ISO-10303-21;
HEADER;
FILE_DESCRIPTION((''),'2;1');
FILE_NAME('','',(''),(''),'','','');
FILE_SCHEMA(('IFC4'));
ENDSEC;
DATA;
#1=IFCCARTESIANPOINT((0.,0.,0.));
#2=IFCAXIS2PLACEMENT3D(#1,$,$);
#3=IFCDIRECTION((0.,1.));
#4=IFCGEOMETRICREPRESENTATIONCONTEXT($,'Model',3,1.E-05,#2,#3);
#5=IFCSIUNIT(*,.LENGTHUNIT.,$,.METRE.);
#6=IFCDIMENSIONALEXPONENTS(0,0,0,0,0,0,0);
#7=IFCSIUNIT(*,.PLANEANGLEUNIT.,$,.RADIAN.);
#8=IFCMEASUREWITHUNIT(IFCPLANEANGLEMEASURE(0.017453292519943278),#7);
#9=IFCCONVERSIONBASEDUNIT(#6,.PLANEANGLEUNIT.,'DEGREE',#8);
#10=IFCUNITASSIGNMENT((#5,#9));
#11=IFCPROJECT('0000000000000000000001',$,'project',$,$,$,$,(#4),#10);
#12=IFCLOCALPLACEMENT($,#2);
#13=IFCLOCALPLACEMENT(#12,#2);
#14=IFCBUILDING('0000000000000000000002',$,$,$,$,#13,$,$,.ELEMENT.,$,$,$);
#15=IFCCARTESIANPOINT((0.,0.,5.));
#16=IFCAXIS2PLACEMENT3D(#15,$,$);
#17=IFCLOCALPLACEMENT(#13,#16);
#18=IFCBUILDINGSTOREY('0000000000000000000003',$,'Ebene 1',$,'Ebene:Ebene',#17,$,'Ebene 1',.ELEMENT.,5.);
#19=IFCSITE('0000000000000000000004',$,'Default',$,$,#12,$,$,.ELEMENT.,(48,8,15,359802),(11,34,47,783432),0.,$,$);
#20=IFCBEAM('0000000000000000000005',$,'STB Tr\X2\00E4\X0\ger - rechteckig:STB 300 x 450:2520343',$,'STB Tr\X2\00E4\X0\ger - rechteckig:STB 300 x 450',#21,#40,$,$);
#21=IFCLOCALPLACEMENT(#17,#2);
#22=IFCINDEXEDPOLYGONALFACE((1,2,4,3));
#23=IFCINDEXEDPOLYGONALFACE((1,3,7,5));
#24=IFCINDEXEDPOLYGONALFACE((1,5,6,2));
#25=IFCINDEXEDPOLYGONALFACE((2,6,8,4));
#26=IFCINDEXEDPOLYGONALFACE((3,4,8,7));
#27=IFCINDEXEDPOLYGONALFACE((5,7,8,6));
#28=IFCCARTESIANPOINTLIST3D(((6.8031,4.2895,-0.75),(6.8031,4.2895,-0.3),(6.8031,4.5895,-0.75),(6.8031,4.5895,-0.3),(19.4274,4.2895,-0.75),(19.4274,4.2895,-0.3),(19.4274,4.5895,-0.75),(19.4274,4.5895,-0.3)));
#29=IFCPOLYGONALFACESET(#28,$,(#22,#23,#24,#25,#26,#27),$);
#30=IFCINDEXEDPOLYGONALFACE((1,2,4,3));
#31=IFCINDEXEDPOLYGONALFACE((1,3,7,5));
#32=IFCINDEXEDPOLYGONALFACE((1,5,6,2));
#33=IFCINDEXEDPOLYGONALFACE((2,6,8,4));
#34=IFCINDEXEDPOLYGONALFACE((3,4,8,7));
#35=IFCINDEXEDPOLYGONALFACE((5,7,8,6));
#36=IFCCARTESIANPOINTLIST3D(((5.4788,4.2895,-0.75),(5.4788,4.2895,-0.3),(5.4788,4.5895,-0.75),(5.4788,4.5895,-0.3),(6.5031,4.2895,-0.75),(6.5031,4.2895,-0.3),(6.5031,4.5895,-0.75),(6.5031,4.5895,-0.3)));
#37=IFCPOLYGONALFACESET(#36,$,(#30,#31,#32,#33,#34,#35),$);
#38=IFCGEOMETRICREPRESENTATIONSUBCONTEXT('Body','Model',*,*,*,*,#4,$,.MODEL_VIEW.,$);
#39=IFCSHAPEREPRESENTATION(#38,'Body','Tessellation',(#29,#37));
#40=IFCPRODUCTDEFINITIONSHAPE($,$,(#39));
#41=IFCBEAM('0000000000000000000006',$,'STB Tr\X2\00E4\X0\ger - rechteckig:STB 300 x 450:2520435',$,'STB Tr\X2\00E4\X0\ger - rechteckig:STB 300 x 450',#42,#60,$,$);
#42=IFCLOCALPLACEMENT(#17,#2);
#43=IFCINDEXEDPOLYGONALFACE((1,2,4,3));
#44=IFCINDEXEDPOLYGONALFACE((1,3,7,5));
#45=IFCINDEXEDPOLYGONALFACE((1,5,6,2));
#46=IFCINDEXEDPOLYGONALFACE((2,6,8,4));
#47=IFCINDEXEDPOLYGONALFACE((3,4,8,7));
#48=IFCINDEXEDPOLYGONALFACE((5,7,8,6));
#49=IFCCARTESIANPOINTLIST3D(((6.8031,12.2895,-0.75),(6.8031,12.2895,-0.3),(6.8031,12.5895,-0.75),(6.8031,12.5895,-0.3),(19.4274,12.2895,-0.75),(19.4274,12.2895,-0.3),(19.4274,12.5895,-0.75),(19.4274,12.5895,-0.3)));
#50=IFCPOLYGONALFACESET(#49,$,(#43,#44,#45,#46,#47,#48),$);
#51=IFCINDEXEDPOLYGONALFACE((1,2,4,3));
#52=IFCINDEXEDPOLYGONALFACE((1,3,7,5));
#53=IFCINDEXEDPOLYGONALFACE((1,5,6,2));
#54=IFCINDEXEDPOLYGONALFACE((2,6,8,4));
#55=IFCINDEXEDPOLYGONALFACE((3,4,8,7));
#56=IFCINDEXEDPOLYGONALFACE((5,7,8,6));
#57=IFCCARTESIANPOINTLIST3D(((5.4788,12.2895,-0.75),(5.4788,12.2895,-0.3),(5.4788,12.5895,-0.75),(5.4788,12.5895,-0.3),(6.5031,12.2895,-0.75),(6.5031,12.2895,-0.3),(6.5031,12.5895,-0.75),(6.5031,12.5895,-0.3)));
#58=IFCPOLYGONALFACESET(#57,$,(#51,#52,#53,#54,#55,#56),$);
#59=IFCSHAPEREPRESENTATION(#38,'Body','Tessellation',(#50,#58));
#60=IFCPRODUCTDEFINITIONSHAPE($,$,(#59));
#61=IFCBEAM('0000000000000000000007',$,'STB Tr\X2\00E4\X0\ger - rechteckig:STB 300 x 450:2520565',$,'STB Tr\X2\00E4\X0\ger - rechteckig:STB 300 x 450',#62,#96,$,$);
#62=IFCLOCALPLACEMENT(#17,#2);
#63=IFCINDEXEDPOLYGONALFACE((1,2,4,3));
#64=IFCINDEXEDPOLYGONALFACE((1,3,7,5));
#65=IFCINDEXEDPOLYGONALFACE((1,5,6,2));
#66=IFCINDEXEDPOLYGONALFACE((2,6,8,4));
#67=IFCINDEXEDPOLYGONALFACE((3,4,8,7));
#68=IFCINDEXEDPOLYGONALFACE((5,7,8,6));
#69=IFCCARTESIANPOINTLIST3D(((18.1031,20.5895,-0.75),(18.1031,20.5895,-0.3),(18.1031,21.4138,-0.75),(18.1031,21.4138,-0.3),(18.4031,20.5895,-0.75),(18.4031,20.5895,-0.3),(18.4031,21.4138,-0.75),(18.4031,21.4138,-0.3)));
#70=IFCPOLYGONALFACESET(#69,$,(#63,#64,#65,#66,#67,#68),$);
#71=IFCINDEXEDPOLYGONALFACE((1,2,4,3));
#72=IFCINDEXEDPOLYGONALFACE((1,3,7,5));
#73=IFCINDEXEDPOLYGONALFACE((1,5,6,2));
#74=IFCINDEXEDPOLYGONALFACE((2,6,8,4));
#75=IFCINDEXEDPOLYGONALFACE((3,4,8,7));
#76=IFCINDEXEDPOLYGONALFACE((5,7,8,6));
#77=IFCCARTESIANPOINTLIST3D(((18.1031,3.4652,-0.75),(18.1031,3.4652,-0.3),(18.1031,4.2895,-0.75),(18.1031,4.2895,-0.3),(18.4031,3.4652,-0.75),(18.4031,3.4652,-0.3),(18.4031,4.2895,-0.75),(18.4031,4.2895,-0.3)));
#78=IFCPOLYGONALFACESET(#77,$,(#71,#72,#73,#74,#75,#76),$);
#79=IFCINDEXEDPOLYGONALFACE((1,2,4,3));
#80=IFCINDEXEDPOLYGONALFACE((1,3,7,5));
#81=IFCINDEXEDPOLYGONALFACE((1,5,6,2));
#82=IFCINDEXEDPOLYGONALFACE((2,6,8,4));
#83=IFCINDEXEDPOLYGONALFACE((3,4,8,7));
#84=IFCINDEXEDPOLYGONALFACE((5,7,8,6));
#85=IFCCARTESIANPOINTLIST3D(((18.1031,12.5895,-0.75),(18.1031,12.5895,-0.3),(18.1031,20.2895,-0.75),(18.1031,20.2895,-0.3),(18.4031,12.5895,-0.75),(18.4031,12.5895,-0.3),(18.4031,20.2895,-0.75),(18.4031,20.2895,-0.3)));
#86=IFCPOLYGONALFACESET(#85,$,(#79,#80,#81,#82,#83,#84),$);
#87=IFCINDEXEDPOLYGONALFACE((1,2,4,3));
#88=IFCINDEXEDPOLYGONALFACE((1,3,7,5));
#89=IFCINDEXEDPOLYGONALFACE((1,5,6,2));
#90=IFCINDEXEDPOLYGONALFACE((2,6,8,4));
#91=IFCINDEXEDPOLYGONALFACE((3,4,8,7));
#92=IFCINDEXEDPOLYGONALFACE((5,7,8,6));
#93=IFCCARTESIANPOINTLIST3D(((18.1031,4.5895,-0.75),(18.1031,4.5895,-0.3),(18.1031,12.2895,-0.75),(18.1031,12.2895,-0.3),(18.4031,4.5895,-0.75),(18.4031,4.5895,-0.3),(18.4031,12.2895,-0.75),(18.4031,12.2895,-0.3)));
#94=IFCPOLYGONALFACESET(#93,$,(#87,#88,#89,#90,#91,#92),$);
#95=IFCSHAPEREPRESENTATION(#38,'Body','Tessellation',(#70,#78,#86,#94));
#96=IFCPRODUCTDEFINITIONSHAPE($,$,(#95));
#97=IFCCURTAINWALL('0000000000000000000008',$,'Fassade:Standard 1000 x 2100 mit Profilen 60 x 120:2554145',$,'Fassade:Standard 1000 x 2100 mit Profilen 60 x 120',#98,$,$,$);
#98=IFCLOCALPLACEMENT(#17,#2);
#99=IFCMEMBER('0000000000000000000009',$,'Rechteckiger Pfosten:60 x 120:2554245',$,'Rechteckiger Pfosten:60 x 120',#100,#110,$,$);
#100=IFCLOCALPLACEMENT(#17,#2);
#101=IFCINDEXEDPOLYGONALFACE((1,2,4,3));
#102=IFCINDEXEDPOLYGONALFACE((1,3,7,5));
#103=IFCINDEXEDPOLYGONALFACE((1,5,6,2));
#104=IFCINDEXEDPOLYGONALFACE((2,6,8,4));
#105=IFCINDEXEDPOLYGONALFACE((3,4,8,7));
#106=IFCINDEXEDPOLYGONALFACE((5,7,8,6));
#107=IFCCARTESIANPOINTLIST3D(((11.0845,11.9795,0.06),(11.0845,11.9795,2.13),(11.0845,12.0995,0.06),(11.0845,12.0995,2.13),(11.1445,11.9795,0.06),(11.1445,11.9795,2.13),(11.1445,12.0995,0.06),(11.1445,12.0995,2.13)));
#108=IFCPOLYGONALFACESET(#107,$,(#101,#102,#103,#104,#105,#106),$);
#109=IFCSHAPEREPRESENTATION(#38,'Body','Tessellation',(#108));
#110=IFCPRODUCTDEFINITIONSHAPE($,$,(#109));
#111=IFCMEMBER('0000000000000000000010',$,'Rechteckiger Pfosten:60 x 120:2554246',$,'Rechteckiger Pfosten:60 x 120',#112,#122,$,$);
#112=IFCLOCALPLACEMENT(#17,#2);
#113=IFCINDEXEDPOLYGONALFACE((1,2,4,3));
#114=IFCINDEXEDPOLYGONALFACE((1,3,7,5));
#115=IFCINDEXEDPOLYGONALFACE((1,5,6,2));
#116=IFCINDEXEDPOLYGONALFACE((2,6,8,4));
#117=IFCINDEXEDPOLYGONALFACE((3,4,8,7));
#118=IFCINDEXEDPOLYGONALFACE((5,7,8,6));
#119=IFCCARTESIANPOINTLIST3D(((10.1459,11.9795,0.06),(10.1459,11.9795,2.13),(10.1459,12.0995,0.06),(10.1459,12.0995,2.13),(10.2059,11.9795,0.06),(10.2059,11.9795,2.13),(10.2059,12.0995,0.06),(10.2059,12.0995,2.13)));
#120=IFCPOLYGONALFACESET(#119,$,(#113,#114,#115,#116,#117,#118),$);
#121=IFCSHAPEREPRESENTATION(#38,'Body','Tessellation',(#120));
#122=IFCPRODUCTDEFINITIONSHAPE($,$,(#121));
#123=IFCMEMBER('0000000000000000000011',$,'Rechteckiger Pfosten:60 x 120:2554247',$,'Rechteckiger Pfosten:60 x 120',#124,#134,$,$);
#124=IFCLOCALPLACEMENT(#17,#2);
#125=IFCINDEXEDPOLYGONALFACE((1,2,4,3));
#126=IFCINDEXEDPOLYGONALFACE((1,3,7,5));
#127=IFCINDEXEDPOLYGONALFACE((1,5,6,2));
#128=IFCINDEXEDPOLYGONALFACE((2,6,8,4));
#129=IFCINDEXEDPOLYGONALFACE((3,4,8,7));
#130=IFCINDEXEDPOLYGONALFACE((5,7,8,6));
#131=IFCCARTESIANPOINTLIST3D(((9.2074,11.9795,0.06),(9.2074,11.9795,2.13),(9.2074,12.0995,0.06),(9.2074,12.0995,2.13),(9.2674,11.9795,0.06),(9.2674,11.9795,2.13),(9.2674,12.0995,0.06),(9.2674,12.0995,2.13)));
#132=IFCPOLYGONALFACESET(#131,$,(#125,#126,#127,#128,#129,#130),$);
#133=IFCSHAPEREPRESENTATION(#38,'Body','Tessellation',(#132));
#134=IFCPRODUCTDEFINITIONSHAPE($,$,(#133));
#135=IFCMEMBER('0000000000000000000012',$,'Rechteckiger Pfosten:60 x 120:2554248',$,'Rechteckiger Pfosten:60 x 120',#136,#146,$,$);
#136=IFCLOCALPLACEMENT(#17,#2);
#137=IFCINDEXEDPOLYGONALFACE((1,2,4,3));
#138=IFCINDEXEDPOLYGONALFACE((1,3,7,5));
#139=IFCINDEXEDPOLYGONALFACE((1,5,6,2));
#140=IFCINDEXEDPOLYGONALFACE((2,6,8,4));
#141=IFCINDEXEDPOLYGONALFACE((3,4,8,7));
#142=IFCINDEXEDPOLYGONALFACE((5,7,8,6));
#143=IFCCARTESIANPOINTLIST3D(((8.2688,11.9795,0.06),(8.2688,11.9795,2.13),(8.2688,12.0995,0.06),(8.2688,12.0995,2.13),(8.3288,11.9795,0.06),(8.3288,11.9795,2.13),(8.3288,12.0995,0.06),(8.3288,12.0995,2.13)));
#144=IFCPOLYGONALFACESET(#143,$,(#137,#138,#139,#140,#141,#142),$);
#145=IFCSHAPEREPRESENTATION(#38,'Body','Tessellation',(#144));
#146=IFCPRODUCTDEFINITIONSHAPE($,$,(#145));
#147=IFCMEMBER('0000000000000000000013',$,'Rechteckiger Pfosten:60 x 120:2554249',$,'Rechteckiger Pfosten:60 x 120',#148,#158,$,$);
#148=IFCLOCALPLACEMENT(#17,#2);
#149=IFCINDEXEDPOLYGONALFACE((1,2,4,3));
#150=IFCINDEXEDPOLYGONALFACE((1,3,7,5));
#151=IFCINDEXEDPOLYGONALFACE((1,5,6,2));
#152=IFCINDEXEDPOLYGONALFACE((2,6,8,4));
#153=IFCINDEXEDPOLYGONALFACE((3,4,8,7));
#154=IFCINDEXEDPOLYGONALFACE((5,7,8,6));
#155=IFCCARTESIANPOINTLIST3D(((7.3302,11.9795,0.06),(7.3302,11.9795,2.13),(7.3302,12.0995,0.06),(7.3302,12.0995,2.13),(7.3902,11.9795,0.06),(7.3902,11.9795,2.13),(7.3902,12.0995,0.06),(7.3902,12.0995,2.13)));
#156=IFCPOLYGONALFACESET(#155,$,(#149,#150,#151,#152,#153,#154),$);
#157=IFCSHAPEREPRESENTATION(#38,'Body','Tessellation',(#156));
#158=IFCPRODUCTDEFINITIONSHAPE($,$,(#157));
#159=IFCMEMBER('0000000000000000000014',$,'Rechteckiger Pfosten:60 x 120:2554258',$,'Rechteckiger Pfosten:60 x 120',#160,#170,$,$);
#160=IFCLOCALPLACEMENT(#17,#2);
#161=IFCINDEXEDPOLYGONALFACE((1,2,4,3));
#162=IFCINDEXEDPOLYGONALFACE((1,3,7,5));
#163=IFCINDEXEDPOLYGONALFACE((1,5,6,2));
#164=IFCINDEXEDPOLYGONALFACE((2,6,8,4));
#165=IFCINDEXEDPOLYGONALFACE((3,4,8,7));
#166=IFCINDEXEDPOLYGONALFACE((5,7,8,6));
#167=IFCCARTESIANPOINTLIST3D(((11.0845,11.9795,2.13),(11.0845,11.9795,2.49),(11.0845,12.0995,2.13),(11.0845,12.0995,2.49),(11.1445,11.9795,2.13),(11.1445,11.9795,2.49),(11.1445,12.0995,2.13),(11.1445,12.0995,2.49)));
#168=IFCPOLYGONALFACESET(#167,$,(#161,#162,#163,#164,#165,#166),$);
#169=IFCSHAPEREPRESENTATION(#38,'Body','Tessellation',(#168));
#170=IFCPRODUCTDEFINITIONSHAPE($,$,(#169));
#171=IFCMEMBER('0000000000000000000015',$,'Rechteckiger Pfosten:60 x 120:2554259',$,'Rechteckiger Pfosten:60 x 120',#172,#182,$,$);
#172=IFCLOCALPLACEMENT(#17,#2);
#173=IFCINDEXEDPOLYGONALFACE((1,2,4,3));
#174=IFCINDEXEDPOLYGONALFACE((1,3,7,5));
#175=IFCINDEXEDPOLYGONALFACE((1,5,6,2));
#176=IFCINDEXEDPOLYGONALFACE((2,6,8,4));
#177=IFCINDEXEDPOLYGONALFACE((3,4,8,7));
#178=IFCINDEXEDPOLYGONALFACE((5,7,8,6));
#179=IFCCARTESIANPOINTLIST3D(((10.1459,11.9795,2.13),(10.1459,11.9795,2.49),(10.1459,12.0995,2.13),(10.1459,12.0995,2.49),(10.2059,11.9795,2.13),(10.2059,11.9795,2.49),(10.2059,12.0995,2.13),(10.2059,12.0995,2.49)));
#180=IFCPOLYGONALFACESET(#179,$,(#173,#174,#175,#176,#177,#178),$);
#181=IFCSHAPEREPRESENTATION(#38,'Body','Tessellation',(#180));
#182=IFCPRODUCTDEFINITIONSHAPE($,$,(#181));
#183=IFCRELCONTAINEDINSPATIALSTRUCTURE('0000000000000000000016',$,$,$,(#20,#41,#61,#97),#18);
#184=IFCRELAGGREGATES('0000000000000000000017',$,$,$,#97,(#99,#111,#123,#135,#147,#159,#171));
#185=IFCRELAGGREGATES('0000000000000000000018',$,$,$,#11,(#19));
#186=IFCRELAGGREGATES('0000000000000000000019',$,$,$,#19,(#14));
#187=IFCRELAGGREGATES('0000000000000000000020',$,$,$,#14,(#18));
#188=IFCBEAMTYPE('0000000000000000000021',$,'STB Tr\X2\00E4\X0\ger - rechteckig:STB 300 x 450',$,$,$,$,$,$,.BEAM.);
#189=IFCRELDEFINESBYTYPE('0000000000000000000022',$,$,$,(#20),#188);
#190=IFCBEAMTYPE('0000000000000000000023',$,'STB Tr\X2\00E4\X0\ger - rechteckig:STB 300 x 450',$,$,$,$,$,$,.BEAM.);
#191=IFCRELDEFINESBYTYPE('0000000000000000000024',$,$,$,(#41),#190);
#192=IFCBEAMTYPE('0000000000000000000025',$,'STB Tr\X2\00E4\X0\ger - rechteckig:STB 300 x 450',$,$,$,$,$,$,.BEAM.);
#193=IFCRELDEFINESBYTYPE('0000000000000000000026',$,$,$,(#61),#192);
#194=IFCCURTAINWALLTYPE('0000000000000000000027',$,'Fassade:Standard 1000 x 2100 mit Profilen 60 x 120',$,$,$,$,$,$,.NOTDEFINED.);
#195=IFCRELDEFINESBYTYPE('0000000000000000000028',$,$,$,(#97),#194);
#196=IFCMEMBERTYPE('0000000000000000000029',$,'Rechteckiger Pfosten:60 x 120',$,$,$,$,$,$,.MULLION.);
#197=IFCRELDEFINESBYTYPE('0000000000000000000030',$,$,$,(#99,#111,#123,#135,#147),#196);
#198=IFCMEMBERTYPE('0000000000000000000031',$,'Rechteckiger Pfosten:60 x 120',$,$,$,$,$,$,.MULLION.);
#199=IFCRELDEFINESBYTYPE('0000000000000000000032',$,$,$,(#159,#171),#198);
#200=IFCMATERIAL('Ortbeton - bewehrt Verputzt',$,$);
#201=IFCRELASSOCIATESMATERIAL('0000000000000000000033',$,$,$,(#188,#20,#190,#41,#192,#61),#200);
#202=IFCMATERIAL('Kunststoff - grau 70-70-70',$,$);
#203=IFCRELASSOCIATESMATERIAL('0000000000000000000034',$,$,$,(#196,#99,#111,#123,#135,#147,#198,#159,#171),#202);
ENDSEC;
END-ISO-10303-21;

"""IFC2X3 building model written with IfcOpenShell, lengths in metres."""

from ifc_helpers import new_model, entity, si_unit, converted_unit, direction, frame, frame_2d, origin, origin_2d_with_axis, place, context, subcontext, project, spatial, rectangle, extrude, source, transform, mapped, material, type_object, type_shapes, element, aggregate, save


model = new_model("IFC2X3")

# Units and contexts
model_context = context("Model", 3, precision=1e-05, world=origin(), true_north=direction((0.0, 1.0)))
body_context = subcontext(model_context, "Body", "Model", "MODEL_VIEW")
ifc_project = project(units=[si_unit("LENGTHUNIT", "METRE"), converted_unit("PLANEANGLEUNIT", "DEGREE", entity("IfcPlaneAngleMeasure", 0.017453292519943278), si_unit("PLANEANGLEUNIT", "RADIAN"), dimensions=[0, 0, 0, 0, 0, 0, 0])], contexts=[model_context])

# Site, building, storey
site_placement = place(None, origin())
site = spatial("IfcSite", under=ifc_project, at=site_placement, Name="Default", CompositionType="ELEMENT", RefLatitude=(48, 8, 15, 359802), RefLongitude=(11, 34, 47, 783432), RefElevation=0.0)
building_placement = place(site_placement, origin())
building = spatial("IfcBuilding", under=site, at=building_placement, CompositionType="ELEMENT")
storey_placement = place(building_placement, frame((0.0, 0.0, 5.0)))
storey = spatial("IfcBuildingStorey", under=building, at=storey_placement, Name="Ebene 1", ObjectType="Ebene:Ebene", LongName="Ebene 1", CompositionType="ELEMENT", Elevation=5.0)

# Beams
ifc_material_1 = material(Name="Ortbeton - bewehrt Verputzt")
beam_type_1 = type_object("IfcBeamType", Name="STB Träger - rechteckig:STB 300 x 450", PredefinedType="BEAM", material=ifc_material_1)
shared_shape_1 = source(origin(), body_context, "Body", "SweptSolid", [
    extrude(rectangle(XDim=0.45, YDim=0.3, at=frame_2d((0.0, 0.0), x_axis=(1.0, 0.0))), frame((6.8031, 4.4395, 4.475), z_axis=(1.0, 0.0, 0.0), x_axis=(0.0, 0.0, -1.0)), (0.0, 0.0, 1.0), 12.6243),
    extrude(rectangle(XDim=0.45, YDim=0.3, at=frame_2d((0.0, 0.0), x_axis=(1.0, 0.0))), frame((5.4788, 4.4395, 4.475), z_axis=(1.0, 0.0, 0.0), x_axis=(0.0, 0.0, -1.0)), (0.0, 0.0, 1.0), 1.0243),
])
type_shapes(beam_type_1, [shared_shape_1])
beam_1_placement = place(storey_placement, frame((0.0, 0.0, -5.0)))
element("IfcBeam", 1, at=beam_1_placement, inside=storey, type_object=beam_type_1, material=ifc_material_1, Name="STB Träger - rechteckig:STB 300 x 450:2520343", ObjectType="STB Träger - rechteckig:STB 300 x 450", context=body_context, shape_type="MappedRepresentation", body=[
    mapped(shared_shape_1, transform((0.0, 0.0, 0.0), scale=1.0)),
])
beam_type_2 = type_object("IfcBeamType", Name="STB Träger - rechteckig:STB 300 x 450", PredefinedType="BEAM", material=ifc_material_1)
shared_shape_2 = source(origin(), body_context, "Body", "SweptSolid", [
    extrude(rectangle(XDim=0.45, YDim=0.3, at=frame_2d((0.0, 0.0), x_axis=(1.0, 0.0))), frame((6.8031, 12.4395, 4.475), z_axis=(1.0, 0.0, 0.0), x_axis=(0.0, 0.0, -1.0)), (0.0, 0.0, 1.0), 12.6243),
    extrude(rectangle(XDim=0.45, YDim=0.3, at=frame_2d((0.0, 0.0), x_axis=(1.0, 0.0))), frame((5.4788, 12.4395, 4.475), z_axis=(1.0, 0.0, 0.0), x_axis=(0.0, 0.0, -1.0)), (0.0, 0.0, 1.0), 1.0243),
])
type_shapes(beam_type_2, [shared_shape_2])
beam_2_placement = place(storey_placement, frame((0.0, 0.0, -5.0)))
element("IfcBeam", 2, at=beam_2_placement, inside=storey, type_object=beam_type_2, material=ifc_material_1, Name="STB Träger - rechteckig:STB 300 x 450:2520435", ObjectType="STB Träger - rechteckig:STB 300 x 450", context=body_context, shape_type="MappedRepresentation", body=[
    mapped(shared_shape_2, transform((0.0, 0.0, 0.0), scale=1.0)),
])
beam_type_3 = type_object("IfcBeamType", Name="STB Träger - rechteckig:STB 300 x 450", PredefinedType="BEAM", material=ifc_material_1)
shared_shape_3 = source(origin(), body_context, "Body", "SweptSolid", [
    extrude(rectangle(XDim=0.45, YDim=0.3, at=frame_2d((0.0, 0.0), x_axis=(0.0, 1.0))), frame((18.2531, 20.5895, 4.475), z_axis=(0.0, 1.0, 0.0), x_axis=(-1.0, 0.0, 0.0)), (0.0, 0.0, 1.0), 0.8243),
    extrude(rectangle(XDim=0.45, YDim=0.3, at=frame_2d((0.0, 0.0), x_axis=(0.0, 1.0))), frame((18.2531, 3.4652, 4.475), z_axis=(0.0, 1.0, 0.0), x_axis=(-1.0, 0.0, 0.0)), (0.0, 0.0, 1.0), 0.8243),
    extrude(rectangle(XDim=0.45, YDim=0.3, at=frame_2d((0.0, 0.0), x_axis=(0.0, 1.0))), frame((18.2531, 12.5895, 4.475), z_axis=(0.0, 1.0, 0.0), x_axis=(-1.0, 0.0, 0.0)), (0.0, 0.0, 1.0), 7.7),
    extrude(rectangle(XDim=0.45, YDim=0.3, at=frame_2d((0.0, 0.0), x_axis=(0.0, 1.0))), frame((18.2531, 4.5895, 4.475), z_axis=(0.0, 1.0, 0.0), x_axis=(-1.0, 0.0, 0.0)), (0.0, 0.0, 1.0), 7.7),
])
type_shapes(beam_type_3, [shared_shape_3])
beam_3_placement = place(storey_placement, frame((0.0, 0.0, -5.0)))
element("IfcBeam", 3, at=beam_3_placement, inside=storey, type_object=beam_type_3, material=ifc_material_1, Name="STB Träger - rechteckig:STB 300 x 450:2520565", ObjectType="STB Träger - rechteckig:STB 300 x 450", context=body_context, shape_type="MappedRepresentation", body=[
    mapped(shared_shape_3, transform((0.0, 0.0, 0.0), scale=1.0)),
])

# Curtain wall, members
curtain_wall_type = type_object("IfcCurtainWallType", Name="Fassade:Standard 1000 x 2100 mit Profilen 60 x 120", PredefinedType="NOTDEFINED")
curtain_wall_placement = place(storey_placement, frame((0.0, 0.0, -5.0)))
curtain_wall = element("IfcCurtainWall", 4, at=curtain_wall_placement, inside=storey, type_object=curtain_wall_type, Name="Fassade:Standard 1000 x 2100 mit Profilen 60 x 120:2554145", ObjectType="Fassade:Standard 1000 x 2100 mit Profilen 60 x 120")
ifc_material_2 = material(Name="Kunststoff - grau 70-70-70")
member_type_1 = type_object("IfcMemberType", Name="Rechteckiger Pfosten:60 x 120", PredefinedType="MULLION", material=ifc_material_2)
shared_shape_4 = source(origin(), body_context, "Body", "SweptSolid", [
    extrude(rectangle(XDim=0.06, YDim=0.12, at=origin_2d_with_axis()), frame((0.0, 0.0, -2.07), z_axis=(0.0, 0.0, 1.0), x_axis=(-1.0, 0.0, 0.0)), (0.0, 0.0, 1.0), 2.07),
])
type_shapes(member_type_1, [shared_shape_4])
member_1_placement = place(curtain_wall_placement, frame((11.1145, 12.0395, 5.06), z_axis=(0.0, 0.0, -1.0), x_axis=(-1.0, 0.0, 0.0)))
member_1 = element("IfcMember", 5, at=member_1_placement, type_object=member_type_1, material=ifc_material_2, Name="Rechteckiger Pfosten:60 x 120:2554245", ObjectType="Rechteckiger Pfosten:60 x 120", context=body_context, shape_type="MappedRepresentation", body=[
    mapped(shared_shape_4, transform((0.0, 0.0, 0.0), scale=1.0)),
])
member_2_placement = place(curtain_wall_placement, frame((10.1759, 12.0395, 5.06), z_axis=(0.0, 0.0, -1.0), x_axis=(-1.0, 0.0, 0.0)))
member_2 = element("IfcMember", 6, at=member_2_placement, type_object=member_type_1, material=ifc_material_2, Name="Rechteckiger Pfosten:60 x 120:2554246", ObjectType="Rechteckiger Pfosten:60 x 120", context=body_context, shape_type="MappedRepresentation", body=[
    mapped(shared_shape_4, transform((0.0, 0.0, 0.0), scale=1.0)),
])
member_3_placement = place(curtain_wall_placement, frame((9.2374, 12.0395, 5.06), z_axis=(0.0, 0.0, -1.0), x_axis=(-1.0, 0.0, 0.0)))
member_3 = element("IfcMember", 7, at=member_3_placement, type_object=member_type_1, material=ifc_material_2, Name="Rechteckiger Pfosten:60 x 120:2554247", ObjectType="Rechteckiger Pfosten:60 x 120", context=body_context, shape_type="MappedRepresentation", body=[
    mapped(shared_shape_4, transform((0.0, 0.0, 0.0), scale=1.0)),
])
member_4_placement = place(curtain_wall_placement, frame((8.2988, 12.0395, 5.06), z_axis=(0.0, 0.0, -1.0), x_axis=(-1.0, 0.0, 0.0)))
member_4 = element("IfcMember", 8, at=member_4_placement, type_object=member_type_1, material=ifc_material_2, Name="Rechteckiger Pfosten:60 x 120:2554248", ObjectType="Rechteckiger Pfosten:60 x 120", context=body_context, shape_type="MappedRepresentation", body=[
    mapped(shared_shape_4, transform((0.0, 0.0, 0.0), scale=1.0)),
])
member_5_placement = place(curtain_wall_placement, frame((7.3602, 12.0395, 5.06), z_axis=(0.0, 0.0, -1.0), x_axis=(-1.0, 0.0, 0.0)))
member_5 = element("IfcMember", 9, at=member_5_placement, type_object=member_type_1, material=ifc_material_2, Name="Rechteckiger Pfosten:60 x 120:2554249", ObjectType="Rechteckiger Pfosten:60 x 120", context=body_context, shape_type="MappedRepresentation", body=[
    mapped(shared_shape_4, transform((0.0, 0.0, 0.0), scale=1.0)),
])
member_type_2 = type_object("IfcMemberType", Name="Rechteckiger Pfosten:60 x 120", PredefinedType="MULLION", material=ifc_material_2)
shared_shape_5 = source(origin(), body_context, "Body", "SweptSolid", [
    extrude(rectangle(XDim=0.06, YDim=0.12, at=frame_2d((0.0, 0.0), x_axis=(1.0, 0.0))), frame((0.0, 0.0, -0.36), z_axis=(0.0, 0.0, 1.0), x_axis=(-1.0, 0.0, 0.0)), (0.0, 0.0, 1.0), 0.36),
])
type_shapes(member_type_2, [shared_shape_5])
member_6_placement = place(curtain_wall_placement, frame((11.1145, 12.0395, 7.13), z_axis=(0.0, 0.0, -1.0), x_axis=(-1.0, 0.0, 0.0)))
member_6 = element("IfcMember", 10, at=member_6_placement, type_object=member_type_2, material=ifc_material_2, Name="Rechteckiger Pfosten:60 x 120:2554258", ObjectType="Rechteckiger Pfosten:60 x 120", context=body_context, shape_type="MappedRepresentation", body=[
    mapped(shared_shape_5, transform((0.0, 0.0, 0.0), scale=1.0)),
])
member_7_placement = place(curtain_wall_placement, frame((10.1759, 12.0395, 7.13), z_axis=(0.0, 0.0, -1.0), x_axis=(-1.0, 0.0, 0.0)))
member_7 = element("IfcMember", 11, at=member_7_placement, type_object=member_type_2, material=ifc_material_2, Name="Rechteckiger Pfosten:60 x 120:2554259", ObjectType="Rechteckiger Pfosten:60 x 120", context=body_context, shape_type="MappedRepresentation", body=[
    mapped(shared_shape_5, transform((0.0, 0.0, 0.0), scale=1.0)),
])

aggregate(curtain_wall, [member_1, member_2, member_3, member_4, member_5, member_6, member_7])

save(model, "model.ifc")
